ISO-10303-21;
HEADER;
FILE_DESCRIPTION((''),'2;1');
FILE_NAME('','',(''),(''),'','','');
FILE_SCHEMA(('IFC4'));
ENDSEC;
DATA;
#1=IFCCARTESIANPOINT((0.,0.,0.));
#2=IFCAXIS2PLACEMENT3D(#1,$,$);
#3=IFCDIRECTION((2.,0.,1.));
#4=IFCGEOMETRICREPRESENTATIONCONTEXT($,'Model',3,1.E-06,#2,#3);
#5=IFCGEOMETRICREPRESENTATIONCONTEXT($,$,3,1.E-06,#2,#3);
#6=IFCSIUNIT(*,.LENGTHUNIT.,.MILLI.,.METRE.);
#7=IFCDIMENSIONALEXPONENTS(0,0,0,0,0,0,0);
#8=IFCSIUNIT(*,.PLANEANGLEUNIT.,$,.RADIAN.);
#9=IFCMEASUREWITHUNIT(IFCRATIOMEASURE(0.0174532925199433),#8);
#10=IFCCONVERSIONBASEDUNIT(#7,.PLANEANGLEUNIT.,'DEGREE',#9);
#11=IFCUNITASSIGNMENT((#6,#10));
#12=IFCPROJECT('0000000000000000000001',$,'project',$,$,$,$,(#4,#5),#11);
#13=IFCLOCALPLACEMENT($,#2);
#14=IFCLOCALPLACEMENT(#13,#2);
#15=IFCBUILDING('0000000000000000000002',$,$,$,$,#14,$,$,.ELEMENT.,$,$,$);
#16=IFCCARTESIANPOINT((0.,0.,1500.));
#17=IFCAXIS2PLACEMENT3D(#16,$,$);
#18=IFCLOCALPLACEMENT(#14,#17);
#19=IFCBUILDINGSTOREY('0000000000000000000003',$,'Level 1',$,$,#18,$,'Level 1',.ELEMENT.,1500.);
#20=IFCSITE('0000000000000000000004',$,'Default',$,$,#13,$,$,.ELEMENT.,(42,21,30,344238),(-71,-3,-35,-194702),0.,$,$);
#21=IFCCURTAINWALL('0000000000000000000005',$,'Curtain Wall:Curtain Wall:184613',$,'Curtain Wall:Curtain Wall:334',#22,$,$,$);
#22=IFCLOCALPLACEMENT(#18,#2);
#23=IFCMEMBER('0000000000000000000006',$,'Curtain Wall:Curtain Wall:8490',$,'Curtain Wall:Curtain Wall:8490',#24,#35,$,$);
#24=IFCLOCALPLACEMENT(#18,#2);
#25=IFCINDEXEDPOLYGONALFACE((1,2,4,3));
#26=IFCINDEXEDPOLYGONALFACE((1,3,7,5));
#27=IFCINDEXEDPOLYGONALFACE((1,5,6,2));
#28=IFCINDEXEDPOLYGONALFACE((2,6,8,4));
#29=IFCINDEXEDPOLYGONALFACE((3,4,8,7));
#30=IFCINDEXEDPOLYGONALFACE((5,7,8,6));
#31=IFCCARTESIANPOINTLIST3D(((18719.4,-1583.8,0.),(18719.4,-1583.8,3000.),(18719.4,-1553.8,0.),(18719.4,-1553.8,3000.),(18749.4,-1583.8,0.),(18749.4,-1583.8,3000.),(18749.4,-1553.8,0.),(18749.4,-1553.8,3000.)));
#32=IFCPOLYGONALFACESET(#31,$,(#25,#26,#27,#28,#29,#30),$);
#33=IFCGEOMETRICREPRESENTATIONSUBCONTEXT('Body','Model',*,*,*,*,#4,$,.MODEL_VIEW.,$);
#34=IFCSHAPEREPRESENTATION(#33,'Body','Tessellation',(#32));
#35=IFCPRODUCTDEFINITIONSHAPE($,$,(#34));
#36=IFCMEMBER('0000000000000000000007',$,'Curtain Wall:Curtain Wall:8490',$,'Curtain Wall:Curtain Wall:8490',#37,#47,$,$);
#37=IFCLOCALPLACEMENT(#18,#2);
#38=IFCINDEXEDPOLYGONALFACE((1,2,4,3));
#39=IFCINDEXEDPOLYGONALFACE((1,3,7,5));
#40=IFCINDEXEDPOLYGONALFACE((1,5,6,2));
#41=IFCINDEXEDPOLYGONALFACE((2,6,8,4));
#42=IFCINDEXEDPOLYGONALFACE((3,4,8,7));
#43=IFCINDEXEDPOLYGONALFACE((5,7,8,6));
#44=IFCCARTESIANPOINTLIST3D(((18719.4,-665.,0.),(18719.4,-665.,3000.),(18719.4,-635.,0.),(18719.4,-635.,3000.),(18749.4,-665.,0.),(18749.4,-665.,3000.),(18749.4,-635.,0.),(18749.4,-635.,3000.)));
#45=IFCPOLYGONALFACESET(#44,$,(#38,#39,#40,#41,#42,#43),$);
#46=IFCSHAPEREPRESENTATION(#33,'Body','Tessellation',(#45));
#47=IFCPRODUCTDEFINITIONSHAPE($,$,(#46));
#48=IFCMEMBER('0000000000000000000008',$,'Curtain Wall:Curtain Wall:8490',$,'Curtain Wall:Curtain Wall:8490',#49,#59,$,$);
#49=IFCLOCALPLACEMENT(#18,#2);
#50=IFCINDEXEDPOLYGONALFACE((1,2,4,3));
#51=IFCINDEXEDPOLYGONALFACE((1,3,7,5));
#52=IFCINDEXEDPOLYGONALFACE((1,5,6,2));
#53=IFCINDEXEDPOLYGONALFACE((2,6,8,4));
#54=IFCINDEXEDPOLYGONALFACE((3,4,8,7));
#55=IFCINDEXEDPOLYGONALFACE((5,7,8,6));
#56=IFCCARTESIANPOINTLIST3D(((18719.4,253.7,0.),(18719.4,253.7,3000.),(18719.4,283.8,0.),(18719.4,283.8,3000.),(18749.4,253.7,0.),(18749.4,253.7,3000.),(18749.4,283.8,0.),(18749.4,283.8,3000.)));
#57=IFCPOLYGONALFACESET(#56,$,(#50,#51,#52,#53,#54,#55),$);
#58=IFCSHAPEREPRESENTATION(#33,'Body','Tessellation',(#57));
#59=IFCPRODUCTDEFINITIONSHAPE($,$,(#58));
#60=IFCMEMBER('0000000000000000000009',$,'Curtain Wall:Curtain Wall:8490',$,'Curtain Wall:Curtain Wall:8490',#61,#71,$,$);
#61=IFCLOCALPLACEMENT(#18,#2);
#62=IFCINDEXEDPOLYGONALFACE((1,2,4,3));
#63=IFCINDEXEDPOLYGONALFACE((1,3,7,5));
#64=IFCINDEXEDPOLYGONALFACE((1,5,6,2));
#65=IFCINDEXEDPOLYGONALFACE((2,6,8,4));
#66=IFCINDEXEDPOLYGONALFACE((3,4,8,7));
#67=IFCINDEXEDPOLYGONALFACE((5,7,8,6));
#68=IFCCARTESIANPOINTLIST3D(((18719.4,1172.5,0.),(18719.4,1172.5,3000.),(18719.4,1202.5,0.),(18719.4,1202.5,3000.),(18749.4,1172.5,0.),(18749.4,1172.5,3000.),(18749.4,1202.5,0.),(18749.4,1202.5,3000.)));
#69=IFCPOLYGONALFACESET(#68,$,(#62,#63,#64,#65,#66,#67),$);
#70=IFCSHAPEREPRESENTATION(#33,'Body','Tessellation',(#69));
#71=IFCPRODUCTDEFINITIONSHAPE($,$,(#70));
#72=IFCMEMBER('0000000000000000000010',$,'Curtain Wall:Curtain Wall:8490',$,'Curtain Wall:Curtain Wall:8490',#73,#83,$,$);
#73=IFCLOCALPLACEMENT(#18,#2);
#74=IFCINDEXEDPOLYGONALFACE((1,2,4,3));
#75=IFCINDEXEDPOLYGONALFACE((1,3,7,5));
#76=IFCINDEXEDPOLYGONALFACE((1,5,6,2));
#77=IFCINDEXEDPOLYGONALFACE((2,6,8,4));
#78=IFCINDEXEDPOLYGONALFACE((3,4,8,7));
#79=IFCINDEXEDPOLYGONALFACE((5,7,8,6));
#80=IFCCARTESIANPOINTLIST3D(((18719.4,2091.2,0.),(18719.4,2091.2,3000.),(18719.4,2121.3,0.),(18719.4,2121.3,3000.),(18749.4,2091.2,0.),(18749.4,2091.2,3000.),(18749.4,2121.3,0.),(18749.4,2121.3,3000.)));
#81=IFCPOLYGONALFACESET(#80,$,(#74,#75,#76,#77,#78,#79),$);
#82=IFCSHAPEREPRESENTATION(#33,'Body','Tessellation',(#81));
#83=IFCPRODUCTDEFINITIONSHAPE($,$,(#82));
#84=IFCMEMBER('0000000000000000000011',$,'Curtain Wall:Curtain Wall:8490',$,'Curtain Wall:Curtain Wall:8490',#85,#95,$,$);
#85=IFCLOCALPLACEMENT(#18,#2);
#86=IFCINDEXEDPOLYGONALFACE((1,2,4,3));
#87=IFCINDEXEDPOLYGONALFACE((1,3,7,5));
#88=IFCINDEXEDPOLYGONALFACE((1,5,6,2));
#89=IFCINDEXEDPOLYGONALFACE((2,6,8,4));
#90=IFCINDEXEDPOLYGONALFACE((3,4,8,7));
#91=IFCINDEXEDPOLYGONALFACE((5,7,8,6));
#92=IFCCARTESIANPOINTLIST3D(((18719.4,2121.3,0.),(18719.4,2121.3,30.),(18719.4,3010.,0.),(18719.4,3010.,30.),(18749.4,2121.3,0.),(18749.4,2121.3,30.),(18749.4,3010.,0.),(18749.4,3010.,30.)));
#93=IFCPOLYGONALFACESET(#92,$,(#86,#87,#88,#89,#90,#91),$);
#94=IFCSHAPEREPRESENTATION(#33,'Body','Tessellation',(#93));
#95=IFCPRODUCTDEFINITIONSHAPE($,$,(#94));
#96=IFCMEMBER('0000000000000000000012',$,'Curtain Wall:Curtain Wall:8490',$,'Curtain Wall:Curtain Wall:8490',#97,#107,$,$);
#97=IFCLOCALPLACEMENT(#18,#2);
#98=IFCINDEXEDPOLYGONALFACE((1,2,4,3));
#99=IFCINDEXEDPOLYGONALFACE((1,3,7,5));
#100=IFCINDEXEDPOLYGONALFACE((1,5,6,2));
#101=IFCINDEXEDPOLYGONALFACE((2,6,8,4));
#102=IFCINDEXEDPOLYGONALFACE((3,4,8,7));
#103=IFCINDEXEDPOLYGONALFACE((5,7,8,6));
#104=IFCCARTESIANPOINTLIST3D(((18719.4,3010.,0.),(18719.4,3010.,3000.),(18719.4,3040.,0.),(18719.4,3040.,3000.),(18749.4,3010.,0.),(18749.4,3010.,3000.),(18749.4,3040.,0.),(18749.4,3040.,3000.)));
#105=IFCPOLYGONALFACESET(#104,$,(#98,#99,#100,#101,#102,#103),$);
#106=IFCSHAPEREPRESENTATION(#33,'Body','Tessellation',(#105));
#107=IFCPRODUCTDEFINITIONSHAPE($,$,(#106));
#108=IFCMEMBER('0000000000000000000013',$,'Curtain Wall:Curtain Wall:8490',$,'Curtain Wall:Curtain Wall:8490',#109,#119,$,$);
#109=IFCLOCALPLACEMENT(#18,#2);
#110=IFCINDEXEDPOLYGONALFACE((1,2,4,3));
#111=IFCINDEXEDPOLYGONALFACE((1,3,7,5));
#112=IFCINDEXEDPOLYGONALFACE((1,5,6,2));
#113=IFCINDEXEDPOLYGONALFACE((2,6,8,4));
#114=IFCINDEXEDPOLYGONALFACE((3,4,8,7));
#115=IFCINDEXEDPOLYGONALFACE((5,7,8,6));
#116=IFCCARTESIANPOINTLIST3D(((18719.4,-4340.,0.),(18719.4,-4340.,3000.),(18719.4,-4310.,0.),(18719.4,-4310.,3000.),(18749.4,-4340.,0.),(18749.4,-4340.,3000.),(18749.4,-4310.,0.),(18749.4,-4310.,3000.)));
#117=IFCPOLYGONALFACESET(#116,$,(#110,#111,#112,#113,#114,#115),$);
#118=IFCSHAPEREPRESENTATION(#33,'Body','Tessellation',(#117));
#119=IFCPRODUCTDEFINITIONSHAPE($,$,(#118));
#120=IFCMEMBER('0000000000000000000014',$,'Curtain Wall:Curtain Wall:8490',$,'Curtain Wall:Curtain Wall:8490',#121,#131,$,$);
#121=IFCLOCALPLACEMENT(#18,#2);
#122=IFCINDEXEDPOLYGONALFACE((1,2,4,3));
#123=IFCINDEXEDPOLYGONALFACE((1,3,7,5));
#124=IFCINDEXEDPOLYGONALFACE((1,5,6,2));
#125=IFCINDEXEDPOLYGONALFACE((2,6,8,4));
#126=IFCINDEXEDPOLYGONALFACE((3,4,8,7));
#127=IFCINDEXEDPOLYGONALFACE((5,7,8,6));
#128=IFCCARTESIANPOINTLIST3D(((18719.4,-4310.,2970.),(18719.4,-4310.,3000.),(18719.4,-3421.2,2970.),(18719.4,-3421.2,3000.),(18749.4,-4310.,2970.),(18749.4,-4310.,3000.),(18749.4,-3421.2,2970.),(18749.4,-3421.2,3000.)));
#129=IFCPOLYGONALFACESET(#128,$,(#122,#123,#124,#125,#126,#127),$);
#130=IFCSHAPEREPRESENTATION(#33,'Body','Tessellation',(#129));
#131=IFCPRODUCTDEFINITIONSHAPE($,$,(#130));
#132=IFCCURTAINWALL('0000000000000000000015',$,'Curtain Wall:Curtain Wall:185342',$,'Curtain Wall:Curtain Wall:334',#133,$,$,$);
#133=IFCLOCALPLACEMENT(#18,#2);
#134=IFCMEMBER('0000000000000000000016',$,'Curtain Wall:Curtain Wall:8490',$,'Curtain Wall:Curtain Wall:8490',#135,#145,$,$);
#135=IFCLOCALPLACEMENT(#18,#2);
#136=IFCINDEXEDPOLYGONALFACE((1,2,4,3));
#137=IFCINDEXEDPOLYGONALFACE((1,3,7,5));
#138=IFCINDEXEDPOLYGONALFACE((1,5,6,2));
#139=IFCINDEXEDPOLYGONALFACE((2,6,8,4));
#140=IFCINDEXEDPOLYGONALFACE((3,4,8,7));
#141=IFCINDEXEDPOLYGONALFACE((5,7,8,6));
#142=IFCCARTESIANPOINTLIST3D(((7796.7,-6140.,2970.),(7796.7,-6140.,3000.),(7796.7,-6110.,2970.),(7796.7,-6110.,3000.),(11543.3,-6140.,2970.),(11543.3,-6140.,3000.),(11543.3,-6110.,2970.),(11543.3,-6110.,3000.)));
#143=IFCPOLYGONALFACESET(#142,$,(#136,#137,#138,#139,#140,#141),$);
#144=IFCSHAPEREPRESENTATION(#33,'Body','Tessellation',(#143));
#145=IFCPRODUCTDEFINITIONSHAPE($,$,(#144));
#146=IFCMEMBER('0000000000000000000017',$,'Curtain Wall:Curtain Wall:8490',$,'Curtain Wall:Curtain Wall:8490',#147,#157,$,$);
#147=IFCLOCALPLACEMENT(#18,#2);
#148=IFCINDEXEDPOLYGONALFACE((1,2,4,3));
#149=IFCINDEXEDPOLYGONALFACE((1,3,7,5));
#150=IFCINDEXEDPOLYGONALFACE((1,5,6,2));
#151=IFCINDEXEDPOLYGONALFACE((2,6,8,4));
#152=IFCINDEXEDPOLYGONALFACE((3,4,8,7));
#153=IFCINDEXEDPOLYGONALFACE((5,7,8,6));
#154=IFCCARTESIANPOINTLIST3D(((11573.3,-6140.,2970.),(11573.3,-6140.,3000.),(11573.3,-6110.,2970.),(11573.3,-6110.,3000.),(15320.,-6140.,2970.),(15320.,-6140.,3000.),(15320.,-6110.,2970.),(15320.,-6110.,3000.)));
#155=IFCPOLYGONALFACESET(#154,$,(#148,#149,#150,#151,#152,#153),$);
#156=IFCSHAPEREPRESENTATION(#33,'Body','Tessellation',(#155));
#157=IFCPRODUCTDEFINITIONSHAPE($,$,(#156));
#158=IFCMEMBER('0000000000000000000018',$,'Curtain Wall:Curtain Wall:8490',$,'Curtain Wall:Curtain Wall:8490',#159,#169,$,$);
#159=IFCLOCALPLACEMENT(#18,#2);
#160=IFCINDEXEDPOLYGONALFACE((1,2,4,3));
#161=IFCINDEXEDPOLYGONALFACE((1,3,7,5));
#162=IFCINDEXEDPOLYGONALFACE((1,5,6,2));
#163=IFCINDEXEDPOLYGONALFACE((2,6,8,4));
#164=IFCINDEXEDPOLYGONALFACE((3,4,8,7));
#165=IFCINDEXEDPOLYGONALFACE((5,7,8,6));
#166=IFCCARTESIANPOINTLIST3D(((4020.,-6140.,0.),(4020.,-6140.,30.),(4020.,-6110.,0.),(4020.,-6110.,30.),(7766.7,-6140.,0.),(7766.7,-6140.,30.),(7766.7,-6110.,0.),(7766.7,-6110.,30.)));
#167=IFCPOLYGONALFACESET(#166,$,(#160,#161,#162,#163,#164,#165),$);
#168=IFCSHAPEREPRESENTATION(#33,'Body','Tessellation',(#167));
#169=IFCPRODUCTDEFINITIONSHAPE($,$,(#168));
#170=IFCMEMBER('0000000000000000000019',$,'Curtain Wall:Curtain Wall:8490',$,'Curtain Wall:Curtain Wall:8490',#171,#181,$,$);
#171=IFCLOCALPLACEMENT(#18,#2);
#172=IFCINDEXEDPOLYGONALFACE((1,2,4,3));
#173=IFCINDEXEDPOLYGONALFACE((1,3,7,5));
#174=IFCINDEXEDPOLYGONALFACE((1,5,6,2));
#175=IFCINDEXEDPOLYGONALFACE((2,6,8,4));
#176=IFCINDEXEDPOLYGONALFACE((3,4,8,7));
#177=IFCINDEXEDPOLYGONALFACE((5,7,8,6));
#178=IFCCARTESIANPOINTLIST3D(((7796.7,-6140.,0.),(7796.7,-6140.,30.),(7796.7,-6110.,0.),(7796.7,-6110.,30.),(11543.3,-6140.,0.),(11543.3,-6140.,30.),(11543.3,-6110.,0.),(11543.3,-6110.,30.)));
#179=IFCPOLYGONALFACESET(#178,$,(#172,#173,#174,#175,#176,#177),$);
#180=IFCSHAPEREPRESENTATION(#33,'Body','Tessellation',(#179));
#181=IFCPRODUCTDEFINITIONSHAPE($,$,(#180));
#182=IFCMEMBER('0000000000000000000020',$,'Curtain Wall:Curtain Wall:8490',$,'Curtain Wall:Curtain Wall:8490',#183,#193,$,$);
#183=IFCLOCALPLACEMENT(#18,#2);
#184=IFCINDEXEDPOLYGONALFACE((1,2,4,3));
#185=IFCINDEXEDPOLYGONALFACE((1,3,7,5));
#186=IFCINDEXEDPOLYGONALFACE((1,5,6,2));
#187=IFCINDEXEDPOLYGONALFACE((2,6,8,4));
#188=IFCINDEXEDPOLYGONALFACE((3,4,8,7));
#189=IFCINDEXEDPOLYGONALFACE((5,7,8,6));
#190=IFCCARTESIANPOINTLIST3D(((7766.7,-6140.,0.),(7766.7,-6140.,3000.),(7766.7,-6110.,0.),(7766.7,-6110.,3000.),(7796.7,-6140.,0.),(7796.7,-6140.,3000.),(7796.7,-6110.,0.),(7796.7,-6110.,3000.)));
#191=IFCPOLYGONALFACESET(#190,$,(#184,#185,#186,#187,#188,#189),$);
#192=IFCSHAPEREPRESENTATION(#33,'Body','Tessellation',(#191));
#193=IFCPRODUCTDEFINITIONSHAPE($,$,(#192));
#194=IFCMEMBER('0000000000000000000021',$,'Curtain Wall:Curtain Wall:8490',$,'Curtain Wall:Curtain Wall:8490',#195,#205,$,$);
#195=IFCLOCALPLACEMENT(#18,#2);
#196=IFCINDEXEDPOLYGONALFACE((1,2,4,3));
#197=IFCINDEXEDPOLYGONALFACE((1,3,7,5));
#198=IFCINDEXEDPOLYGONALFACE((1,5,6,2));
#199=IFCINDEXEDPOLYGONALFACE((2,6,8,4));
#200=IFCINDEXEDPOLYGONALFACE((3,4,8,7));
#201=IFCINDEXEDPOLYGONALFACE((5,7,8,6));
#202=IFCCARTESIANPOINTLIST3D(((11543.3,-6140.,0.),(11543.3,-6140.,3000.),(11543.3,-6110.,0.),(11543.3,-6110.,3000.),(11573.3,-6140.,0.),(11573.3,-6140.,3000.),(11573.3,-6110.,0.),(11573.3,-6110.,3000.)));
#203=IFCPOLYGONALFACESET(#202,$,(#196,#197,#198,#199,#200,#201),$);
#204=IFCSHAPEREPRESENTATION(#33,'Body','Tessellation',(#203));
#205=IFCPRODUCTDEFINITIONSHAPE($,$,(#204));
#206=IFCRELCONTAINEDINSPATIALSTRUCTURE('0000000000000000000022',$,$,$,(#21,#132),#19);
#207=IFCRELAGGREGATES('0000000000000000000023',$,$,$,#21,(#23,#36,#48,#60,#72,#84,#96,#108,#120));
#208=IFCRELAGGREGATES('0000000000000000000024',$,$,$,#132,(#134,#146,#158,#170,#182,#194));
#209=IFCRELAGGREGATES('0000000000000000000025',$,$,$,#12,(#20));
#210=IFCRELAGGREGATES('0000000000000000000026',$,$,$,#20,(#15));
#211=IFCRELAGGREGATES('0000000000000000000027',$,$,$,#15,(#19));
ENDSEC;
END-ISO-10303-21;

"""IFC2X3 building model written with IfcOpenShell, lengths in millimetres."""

from ifc_helpers import new_model, entity, si_unit, converted_unit, direction, frame, frame_2d, origin, place, context, subcontext, project, spatial, rectangle, extrude, element, aggregate, save


model = new_model("IFC2X3")

# Units and contexts
model_context = context("Model", 3, precision=1e-06, world=origin(), true_north=direction((2.0, 0.0, 1.0)))
context_of_model = context(None, 3, precision=1e-06, world=origin(), true_north=direction((2.0, 0.0, 1.0)))
body_context = subcontext(model_context, "Body", "Model", "MODEL_VIEW")
ifc_project = project(units=[si_unit("LENGTHUNIT", "METRE", prefix="MILLI"), converted_unit("PLANEANGLEUNIT", "DEGREE", entity("IfcRatioMeasure", 0.0174532925199433), si_unit("PLANEANGLEUNIT", "RADIAN"), dimensions=[0, 0, 0, 0, 0, 0, 0])], contexts=[model_context, context_of_model])

# Site, building, storey
site_placement = place(None, origin())
site = spatial("IfcSite", under=ifc_project, at=site_placement, Name="Default", CompositionType="ELEMENT", RefLatitude=(42, 21, 30, 344238), RefLongitude=(-71, -3, -35, -194702), RefElevation=0.0)
building_placement = place(site_placement, origin())
building = spatial("IfcBuilding", under=site, at=building_placement, CompositionType="ELEMENT")
storey_placement = place(building_placement, frame((0.0, 0.0, 1500.0)))
storey = spatial("IfcBuildingStorey", under=building, at=storey_placement, Name="Level 1", LongName="Level 1", CompositionType="ELEMENT", Elevation=1500.0)

# Curtain walls, members
curtain_wall_1_placement = place(storey_placement, origin())
curtain_wall_1 = element("IfcCurtainWall", 1, at=curtain_wall_1_placement, inside=storey, Name="Curtain Wall:Curtain Wall:184613", ObjectType="Curtain Wall:Curtain Wall:334")
member_1_placement = place(storey_placement, origin())
member_1 = element("IfcMember", 2, at=member_1_placement, Name="Curtain Wall:Curtain Wall:8490", ObjectType="Curtain Wall:Curtain Wall:8490", context=body_context, shape_type="SweptSolid", body=[
    extrude(rectangle(XDim=30.0, YDim=30.0, at=frame_2d((0.0, 0.0), x_axis=(1.0, 0.0))), frame((18734.4, -1568.8, 0.0)), (0.0, 0.0, 1.0), 3000.0),
])
member_2_placement = place(storey_placement, origin())
member_2 = element("IfcMember", 3, at=member_2_placement, Name="Curtain Wall:Curtain Wall:8490", ObjectType="Curtain Wall:Curtain Wall:8490", context=body_context, shape_type="SweptSolid", body=[
    extrude(rectangle(XDim=30.0, YDim=30.0, at=frame_2d((0.0, 0.0), x_axis=(1.0, 0.0))), frame((18734.4, -650.0, 0.0)), (0.0, 0.0, 1.0), 3000.0),
])
member_3_placement = place(storey_placement, origin())
member_3 = element("IfcMember", 4, at=member_3_placement, Name="Curtain Wall:Curtain Wall:8490", ObjectType="Curtain Wall:Curtain Wall:8490", context=body_context, shape_type="SweptSolid", body=[
    extrude(rectangle(XDim=30.0, YDim=30.0, at=frame_2d((0.0, 0.0), x_axis=(1.0, 0.0))), frame((18734.4, 268.8, 0.0)), (0.0, 0.0, 1.0), 3000.0),
])
member_4_placement = place(storey_placement, origin())
member_4 = element("IfcMember", 5, at=member_4_placement, Name="Curtain Wall:Curtain Wall:8490", ObjectType="Curtain Wall:Curtain Wall:8490", context=body_context, shape_type="SweptSolid", body=[
    extrude(rectangle(XDim=30.0, YDim=30.0, at=frame_2d((0.0, 0.0), x_axis=(1.0, 0.0))), frame((18734.4, 1187.5, 0.0)), (0.0, 0.0, 1.0), 3000.0),
])
member_5_placement = place(storey_placement, origin())
member_5 = element("IfcMember", 6, at=member_5_placement, Name="Curtain Wall:Curtain Wall:8490", ObjectType="Curtain Wall:Curtain Wall:8490", context=body_context, shape_type="SweptSolid", body=[
    extrude(rectangle(XDim=30.0, YDim=30.0, at=frame_2d((0.0, 0.0), x_axis=(1.0, 0.0))), frame((18734.4, 2106.2, 0.0)), (0.0, 0.0, 1.0), 3000.0),
])
member_6_placement = place(storey_placement, origin())
member_6 = element("IfcMember", 7, at=member_6_placement, Name="Curtain Wall:Curtain Wall:8490", ObjectType="Curtain Wall:Curtain Wall:8490", context=body_context, shape_type="SweptSolid", body=[
    extrude(rectangle(XDim=888.8, YDim=30.0, at=frame_2d((0.0, 0.0), x_axis=(1.0, 0.0))), frame((18734.4, 2565.6, 0.0), z_axis=(0.0, 0.0, 1.0), x_axis=(0.0, -1.0, 0.0)), (0.0, 0.0, 1.0), 30.0),
])
member_7_placement = place(storey_placement, origin())
member_7 = element("IfcMember", 8, at=member_7_placement, Name="Curtain Wall:Curtain Wall:8490", ObjectType="Curtain Wall:Curtain Wall:8490", context=body_context, shape_type="SweptSolid", body=[
    extrude(rectangle(XDim=30.0, YDim=30.0, at=frame_2d((0.0, 0.0), x_axis=(1.0, 0.0))), frame((18734.4, 3025.0, 0.0), z_axis=(0.0, 0.0, 1.0), x_axis=(0.0, -1.0, 0.0)), (0.0, 0.0, 1.0), 3000.0),
])
member_8_placement = place(storey_placement, origin())
member_8 = element("IfcMember", 9, at=member_8_placement, Name="Curtain Wall:Curtain Wall:8490", ObjectType="Curtain Wall:Curtain Wall:8490", context=body_context, shape_type="SweptSolid", body=[
    extrude(rectangle(XDim=30.0, YDim=30.0, at=frame_2d((0.0, 0.0), x_axis=(1.0, 0.0))), frame((18734.4, -4325.0, 0.0)), (0.0, 0.0, 1.0), 3000.0),
])
member_9_placement = place(storey_placement, origin())
member_9 = element("IfcMember", 10, at=member_9_placement, Name="Curtain Wall:Curtain Wall:8490", ObjectType="Curtain Wall:Curtain Wall:8490", context=body_context, shape_type="SweptSolid", body=[
    extrude(rectangle(XDim=888.8, YDim=30.0, at=frame_2d((0.0, 0.0), x_axis=(1.0, 0.0))), frame((18734.4, -3865.6, 2970.0), z_axis=(0.0, 0.0, 1.0), x_axis=(0.0, 1.0, 0.0)), (0.0, 0.0, 1.0), 30.0),
])
aggregate(curtain_wall_1, [member_1, member_2, member_3, member_4, member_5, member_6, member_7, member_8, member_9])
curtain_wall_2_placement = place(storey_placement, origin())
curtain_wall_2 = element("IfcCurtainWall", 11, at=curtain_wall_2_placement, inside=storey, Name="Curtain Wall:Curtain Wall:185342", ObjectType="Curtain Wall:Curtain Wall:334")
member_10_placement = place(storey_placement, origin())
member_10 = element("IfcMember", 12, at=member_10_placement, Name="Curtain Wall:Curtain Wall:8490", ObjectType="Curtain Wall:Curtain Wall:8490", context=body_context, shape_type="SweptSolid", body=[
    extrude(rectangle(XDim=3746.7, YDim=30.0, at=frame_2d((0.0, 0.0), x_axis=(1.0, 0.0))), frame((9670.0, -6125.0, 2970.0)), (0.0, 0.0, 1.0), 30.0),
])
member_11_placement = place(storey_placement, origin())
member_11 = element("IfcMember", 13, at=member_11_placement, Name="Curtain Wall:Curtain Wall:8490", ObjectType="Curtain Wall:Curtain Wall:8490", context=body_context, shape_type="SweptSolid", body=[
    extrude(rectangle(XDim=3746.7, YDim=30.0, at=frame_2d((0.0, 0.0), x_axis=(1.0, 0.0))), frame((13446.7, -6125.0, 2970.0)), (0.0, 0.0, 1.0), 30.0),
])
member_12_placement = place(storey_placement, origin())
member_12 = element("IfcMember", 14, at=member_12_placement, Name="Curtain Wall:Curtain Wall:8490", ObjectType="Curtain Wall:Curtain Wall:8490", context=body_context, shape_type="SweptSolid", body=[
    extrude(rectangle(XDim=3746.7, YDim=30.0, at=frame_2d((0.0, 0.0), x_axis=(1.0, 0.0))), frame((5893.3, -6125.0, 0.0), z_axis=(0.0, 0.0, 1.0), x_axis=(-1.0, 0.0, 0.0)), (0.0, 0.0, 1.0), 30.0),
])
member_13_placement = place(storey_placement, origin())
member_13 = element("IfcMember", 15, at=member_13_placement, Name="Curtain Wall:Curtain Wall:8490", ObjectType="Curtain Wall:Curtain Wall:8490", context=body_context, shape_type="SweptSolid", body=[
    extrude(rectangle(XDim=3746.7, YDim=30.0, at=frame_2d((0.0, 0.0), x_axis=(1.0, 0.0))), frame((9670.0, -6125.0, 0.0), z_axis=(0.0, 0.0, 1.0), x_axis=(-1.0, 0.0, 0.0)), (0.0, 0.0, 1.0), 30.0),
])
member_14_placement = place(storey_placement, origin())
member_14 = element("IfcMember", 16, at=member_14_placement, Name="Curtain Wall:Curtain Wall:8490", ObjectType="Curtain Wall:Curtain Wall:8490", context=body_context, shape_type="SweptSolid", body=[
    extrude(rectangle(XDim=30.0, YDim=30.0, at=frame_2d((0.0, 0.0), x_axis=(1.0, 0.0))), frame((7781.7, -6125.0, 0.0), z_axis=(0.0, 0.0, 1.0), x_axis=(0.0, -1.0, 0.0)), (0.0, 0.0, 1.0), 3000.0),
])
member_15_placement = place(storey_placement, origin())
member_15 = element("IfcMember", 17, at=member_15_placement, Name="Curtain Wall:Curtain Wall:8490", ObjectType="Curtain Wall:Curtain Wall:8490", context=body_context, shape_type="SweptSolid", body=[
    extrude(rectangle(XDim=30.0, YDim=30.0, at=frame_2d((0.0, 0.0), x_axis=(1.0, 0.0))), frame((11558.3, -6125.0, 0.0), z_axis=(0.0, 0.0, 1.0), x_axis=(0.0, -1.0, 0.0)), (0.0, 0.0, 1.0), 3000.0),
])
aggregate(curtain_wall_2, [member_10, member_11, member_12, member_13, member_14, member_15])

save(model, "model.ifc")
